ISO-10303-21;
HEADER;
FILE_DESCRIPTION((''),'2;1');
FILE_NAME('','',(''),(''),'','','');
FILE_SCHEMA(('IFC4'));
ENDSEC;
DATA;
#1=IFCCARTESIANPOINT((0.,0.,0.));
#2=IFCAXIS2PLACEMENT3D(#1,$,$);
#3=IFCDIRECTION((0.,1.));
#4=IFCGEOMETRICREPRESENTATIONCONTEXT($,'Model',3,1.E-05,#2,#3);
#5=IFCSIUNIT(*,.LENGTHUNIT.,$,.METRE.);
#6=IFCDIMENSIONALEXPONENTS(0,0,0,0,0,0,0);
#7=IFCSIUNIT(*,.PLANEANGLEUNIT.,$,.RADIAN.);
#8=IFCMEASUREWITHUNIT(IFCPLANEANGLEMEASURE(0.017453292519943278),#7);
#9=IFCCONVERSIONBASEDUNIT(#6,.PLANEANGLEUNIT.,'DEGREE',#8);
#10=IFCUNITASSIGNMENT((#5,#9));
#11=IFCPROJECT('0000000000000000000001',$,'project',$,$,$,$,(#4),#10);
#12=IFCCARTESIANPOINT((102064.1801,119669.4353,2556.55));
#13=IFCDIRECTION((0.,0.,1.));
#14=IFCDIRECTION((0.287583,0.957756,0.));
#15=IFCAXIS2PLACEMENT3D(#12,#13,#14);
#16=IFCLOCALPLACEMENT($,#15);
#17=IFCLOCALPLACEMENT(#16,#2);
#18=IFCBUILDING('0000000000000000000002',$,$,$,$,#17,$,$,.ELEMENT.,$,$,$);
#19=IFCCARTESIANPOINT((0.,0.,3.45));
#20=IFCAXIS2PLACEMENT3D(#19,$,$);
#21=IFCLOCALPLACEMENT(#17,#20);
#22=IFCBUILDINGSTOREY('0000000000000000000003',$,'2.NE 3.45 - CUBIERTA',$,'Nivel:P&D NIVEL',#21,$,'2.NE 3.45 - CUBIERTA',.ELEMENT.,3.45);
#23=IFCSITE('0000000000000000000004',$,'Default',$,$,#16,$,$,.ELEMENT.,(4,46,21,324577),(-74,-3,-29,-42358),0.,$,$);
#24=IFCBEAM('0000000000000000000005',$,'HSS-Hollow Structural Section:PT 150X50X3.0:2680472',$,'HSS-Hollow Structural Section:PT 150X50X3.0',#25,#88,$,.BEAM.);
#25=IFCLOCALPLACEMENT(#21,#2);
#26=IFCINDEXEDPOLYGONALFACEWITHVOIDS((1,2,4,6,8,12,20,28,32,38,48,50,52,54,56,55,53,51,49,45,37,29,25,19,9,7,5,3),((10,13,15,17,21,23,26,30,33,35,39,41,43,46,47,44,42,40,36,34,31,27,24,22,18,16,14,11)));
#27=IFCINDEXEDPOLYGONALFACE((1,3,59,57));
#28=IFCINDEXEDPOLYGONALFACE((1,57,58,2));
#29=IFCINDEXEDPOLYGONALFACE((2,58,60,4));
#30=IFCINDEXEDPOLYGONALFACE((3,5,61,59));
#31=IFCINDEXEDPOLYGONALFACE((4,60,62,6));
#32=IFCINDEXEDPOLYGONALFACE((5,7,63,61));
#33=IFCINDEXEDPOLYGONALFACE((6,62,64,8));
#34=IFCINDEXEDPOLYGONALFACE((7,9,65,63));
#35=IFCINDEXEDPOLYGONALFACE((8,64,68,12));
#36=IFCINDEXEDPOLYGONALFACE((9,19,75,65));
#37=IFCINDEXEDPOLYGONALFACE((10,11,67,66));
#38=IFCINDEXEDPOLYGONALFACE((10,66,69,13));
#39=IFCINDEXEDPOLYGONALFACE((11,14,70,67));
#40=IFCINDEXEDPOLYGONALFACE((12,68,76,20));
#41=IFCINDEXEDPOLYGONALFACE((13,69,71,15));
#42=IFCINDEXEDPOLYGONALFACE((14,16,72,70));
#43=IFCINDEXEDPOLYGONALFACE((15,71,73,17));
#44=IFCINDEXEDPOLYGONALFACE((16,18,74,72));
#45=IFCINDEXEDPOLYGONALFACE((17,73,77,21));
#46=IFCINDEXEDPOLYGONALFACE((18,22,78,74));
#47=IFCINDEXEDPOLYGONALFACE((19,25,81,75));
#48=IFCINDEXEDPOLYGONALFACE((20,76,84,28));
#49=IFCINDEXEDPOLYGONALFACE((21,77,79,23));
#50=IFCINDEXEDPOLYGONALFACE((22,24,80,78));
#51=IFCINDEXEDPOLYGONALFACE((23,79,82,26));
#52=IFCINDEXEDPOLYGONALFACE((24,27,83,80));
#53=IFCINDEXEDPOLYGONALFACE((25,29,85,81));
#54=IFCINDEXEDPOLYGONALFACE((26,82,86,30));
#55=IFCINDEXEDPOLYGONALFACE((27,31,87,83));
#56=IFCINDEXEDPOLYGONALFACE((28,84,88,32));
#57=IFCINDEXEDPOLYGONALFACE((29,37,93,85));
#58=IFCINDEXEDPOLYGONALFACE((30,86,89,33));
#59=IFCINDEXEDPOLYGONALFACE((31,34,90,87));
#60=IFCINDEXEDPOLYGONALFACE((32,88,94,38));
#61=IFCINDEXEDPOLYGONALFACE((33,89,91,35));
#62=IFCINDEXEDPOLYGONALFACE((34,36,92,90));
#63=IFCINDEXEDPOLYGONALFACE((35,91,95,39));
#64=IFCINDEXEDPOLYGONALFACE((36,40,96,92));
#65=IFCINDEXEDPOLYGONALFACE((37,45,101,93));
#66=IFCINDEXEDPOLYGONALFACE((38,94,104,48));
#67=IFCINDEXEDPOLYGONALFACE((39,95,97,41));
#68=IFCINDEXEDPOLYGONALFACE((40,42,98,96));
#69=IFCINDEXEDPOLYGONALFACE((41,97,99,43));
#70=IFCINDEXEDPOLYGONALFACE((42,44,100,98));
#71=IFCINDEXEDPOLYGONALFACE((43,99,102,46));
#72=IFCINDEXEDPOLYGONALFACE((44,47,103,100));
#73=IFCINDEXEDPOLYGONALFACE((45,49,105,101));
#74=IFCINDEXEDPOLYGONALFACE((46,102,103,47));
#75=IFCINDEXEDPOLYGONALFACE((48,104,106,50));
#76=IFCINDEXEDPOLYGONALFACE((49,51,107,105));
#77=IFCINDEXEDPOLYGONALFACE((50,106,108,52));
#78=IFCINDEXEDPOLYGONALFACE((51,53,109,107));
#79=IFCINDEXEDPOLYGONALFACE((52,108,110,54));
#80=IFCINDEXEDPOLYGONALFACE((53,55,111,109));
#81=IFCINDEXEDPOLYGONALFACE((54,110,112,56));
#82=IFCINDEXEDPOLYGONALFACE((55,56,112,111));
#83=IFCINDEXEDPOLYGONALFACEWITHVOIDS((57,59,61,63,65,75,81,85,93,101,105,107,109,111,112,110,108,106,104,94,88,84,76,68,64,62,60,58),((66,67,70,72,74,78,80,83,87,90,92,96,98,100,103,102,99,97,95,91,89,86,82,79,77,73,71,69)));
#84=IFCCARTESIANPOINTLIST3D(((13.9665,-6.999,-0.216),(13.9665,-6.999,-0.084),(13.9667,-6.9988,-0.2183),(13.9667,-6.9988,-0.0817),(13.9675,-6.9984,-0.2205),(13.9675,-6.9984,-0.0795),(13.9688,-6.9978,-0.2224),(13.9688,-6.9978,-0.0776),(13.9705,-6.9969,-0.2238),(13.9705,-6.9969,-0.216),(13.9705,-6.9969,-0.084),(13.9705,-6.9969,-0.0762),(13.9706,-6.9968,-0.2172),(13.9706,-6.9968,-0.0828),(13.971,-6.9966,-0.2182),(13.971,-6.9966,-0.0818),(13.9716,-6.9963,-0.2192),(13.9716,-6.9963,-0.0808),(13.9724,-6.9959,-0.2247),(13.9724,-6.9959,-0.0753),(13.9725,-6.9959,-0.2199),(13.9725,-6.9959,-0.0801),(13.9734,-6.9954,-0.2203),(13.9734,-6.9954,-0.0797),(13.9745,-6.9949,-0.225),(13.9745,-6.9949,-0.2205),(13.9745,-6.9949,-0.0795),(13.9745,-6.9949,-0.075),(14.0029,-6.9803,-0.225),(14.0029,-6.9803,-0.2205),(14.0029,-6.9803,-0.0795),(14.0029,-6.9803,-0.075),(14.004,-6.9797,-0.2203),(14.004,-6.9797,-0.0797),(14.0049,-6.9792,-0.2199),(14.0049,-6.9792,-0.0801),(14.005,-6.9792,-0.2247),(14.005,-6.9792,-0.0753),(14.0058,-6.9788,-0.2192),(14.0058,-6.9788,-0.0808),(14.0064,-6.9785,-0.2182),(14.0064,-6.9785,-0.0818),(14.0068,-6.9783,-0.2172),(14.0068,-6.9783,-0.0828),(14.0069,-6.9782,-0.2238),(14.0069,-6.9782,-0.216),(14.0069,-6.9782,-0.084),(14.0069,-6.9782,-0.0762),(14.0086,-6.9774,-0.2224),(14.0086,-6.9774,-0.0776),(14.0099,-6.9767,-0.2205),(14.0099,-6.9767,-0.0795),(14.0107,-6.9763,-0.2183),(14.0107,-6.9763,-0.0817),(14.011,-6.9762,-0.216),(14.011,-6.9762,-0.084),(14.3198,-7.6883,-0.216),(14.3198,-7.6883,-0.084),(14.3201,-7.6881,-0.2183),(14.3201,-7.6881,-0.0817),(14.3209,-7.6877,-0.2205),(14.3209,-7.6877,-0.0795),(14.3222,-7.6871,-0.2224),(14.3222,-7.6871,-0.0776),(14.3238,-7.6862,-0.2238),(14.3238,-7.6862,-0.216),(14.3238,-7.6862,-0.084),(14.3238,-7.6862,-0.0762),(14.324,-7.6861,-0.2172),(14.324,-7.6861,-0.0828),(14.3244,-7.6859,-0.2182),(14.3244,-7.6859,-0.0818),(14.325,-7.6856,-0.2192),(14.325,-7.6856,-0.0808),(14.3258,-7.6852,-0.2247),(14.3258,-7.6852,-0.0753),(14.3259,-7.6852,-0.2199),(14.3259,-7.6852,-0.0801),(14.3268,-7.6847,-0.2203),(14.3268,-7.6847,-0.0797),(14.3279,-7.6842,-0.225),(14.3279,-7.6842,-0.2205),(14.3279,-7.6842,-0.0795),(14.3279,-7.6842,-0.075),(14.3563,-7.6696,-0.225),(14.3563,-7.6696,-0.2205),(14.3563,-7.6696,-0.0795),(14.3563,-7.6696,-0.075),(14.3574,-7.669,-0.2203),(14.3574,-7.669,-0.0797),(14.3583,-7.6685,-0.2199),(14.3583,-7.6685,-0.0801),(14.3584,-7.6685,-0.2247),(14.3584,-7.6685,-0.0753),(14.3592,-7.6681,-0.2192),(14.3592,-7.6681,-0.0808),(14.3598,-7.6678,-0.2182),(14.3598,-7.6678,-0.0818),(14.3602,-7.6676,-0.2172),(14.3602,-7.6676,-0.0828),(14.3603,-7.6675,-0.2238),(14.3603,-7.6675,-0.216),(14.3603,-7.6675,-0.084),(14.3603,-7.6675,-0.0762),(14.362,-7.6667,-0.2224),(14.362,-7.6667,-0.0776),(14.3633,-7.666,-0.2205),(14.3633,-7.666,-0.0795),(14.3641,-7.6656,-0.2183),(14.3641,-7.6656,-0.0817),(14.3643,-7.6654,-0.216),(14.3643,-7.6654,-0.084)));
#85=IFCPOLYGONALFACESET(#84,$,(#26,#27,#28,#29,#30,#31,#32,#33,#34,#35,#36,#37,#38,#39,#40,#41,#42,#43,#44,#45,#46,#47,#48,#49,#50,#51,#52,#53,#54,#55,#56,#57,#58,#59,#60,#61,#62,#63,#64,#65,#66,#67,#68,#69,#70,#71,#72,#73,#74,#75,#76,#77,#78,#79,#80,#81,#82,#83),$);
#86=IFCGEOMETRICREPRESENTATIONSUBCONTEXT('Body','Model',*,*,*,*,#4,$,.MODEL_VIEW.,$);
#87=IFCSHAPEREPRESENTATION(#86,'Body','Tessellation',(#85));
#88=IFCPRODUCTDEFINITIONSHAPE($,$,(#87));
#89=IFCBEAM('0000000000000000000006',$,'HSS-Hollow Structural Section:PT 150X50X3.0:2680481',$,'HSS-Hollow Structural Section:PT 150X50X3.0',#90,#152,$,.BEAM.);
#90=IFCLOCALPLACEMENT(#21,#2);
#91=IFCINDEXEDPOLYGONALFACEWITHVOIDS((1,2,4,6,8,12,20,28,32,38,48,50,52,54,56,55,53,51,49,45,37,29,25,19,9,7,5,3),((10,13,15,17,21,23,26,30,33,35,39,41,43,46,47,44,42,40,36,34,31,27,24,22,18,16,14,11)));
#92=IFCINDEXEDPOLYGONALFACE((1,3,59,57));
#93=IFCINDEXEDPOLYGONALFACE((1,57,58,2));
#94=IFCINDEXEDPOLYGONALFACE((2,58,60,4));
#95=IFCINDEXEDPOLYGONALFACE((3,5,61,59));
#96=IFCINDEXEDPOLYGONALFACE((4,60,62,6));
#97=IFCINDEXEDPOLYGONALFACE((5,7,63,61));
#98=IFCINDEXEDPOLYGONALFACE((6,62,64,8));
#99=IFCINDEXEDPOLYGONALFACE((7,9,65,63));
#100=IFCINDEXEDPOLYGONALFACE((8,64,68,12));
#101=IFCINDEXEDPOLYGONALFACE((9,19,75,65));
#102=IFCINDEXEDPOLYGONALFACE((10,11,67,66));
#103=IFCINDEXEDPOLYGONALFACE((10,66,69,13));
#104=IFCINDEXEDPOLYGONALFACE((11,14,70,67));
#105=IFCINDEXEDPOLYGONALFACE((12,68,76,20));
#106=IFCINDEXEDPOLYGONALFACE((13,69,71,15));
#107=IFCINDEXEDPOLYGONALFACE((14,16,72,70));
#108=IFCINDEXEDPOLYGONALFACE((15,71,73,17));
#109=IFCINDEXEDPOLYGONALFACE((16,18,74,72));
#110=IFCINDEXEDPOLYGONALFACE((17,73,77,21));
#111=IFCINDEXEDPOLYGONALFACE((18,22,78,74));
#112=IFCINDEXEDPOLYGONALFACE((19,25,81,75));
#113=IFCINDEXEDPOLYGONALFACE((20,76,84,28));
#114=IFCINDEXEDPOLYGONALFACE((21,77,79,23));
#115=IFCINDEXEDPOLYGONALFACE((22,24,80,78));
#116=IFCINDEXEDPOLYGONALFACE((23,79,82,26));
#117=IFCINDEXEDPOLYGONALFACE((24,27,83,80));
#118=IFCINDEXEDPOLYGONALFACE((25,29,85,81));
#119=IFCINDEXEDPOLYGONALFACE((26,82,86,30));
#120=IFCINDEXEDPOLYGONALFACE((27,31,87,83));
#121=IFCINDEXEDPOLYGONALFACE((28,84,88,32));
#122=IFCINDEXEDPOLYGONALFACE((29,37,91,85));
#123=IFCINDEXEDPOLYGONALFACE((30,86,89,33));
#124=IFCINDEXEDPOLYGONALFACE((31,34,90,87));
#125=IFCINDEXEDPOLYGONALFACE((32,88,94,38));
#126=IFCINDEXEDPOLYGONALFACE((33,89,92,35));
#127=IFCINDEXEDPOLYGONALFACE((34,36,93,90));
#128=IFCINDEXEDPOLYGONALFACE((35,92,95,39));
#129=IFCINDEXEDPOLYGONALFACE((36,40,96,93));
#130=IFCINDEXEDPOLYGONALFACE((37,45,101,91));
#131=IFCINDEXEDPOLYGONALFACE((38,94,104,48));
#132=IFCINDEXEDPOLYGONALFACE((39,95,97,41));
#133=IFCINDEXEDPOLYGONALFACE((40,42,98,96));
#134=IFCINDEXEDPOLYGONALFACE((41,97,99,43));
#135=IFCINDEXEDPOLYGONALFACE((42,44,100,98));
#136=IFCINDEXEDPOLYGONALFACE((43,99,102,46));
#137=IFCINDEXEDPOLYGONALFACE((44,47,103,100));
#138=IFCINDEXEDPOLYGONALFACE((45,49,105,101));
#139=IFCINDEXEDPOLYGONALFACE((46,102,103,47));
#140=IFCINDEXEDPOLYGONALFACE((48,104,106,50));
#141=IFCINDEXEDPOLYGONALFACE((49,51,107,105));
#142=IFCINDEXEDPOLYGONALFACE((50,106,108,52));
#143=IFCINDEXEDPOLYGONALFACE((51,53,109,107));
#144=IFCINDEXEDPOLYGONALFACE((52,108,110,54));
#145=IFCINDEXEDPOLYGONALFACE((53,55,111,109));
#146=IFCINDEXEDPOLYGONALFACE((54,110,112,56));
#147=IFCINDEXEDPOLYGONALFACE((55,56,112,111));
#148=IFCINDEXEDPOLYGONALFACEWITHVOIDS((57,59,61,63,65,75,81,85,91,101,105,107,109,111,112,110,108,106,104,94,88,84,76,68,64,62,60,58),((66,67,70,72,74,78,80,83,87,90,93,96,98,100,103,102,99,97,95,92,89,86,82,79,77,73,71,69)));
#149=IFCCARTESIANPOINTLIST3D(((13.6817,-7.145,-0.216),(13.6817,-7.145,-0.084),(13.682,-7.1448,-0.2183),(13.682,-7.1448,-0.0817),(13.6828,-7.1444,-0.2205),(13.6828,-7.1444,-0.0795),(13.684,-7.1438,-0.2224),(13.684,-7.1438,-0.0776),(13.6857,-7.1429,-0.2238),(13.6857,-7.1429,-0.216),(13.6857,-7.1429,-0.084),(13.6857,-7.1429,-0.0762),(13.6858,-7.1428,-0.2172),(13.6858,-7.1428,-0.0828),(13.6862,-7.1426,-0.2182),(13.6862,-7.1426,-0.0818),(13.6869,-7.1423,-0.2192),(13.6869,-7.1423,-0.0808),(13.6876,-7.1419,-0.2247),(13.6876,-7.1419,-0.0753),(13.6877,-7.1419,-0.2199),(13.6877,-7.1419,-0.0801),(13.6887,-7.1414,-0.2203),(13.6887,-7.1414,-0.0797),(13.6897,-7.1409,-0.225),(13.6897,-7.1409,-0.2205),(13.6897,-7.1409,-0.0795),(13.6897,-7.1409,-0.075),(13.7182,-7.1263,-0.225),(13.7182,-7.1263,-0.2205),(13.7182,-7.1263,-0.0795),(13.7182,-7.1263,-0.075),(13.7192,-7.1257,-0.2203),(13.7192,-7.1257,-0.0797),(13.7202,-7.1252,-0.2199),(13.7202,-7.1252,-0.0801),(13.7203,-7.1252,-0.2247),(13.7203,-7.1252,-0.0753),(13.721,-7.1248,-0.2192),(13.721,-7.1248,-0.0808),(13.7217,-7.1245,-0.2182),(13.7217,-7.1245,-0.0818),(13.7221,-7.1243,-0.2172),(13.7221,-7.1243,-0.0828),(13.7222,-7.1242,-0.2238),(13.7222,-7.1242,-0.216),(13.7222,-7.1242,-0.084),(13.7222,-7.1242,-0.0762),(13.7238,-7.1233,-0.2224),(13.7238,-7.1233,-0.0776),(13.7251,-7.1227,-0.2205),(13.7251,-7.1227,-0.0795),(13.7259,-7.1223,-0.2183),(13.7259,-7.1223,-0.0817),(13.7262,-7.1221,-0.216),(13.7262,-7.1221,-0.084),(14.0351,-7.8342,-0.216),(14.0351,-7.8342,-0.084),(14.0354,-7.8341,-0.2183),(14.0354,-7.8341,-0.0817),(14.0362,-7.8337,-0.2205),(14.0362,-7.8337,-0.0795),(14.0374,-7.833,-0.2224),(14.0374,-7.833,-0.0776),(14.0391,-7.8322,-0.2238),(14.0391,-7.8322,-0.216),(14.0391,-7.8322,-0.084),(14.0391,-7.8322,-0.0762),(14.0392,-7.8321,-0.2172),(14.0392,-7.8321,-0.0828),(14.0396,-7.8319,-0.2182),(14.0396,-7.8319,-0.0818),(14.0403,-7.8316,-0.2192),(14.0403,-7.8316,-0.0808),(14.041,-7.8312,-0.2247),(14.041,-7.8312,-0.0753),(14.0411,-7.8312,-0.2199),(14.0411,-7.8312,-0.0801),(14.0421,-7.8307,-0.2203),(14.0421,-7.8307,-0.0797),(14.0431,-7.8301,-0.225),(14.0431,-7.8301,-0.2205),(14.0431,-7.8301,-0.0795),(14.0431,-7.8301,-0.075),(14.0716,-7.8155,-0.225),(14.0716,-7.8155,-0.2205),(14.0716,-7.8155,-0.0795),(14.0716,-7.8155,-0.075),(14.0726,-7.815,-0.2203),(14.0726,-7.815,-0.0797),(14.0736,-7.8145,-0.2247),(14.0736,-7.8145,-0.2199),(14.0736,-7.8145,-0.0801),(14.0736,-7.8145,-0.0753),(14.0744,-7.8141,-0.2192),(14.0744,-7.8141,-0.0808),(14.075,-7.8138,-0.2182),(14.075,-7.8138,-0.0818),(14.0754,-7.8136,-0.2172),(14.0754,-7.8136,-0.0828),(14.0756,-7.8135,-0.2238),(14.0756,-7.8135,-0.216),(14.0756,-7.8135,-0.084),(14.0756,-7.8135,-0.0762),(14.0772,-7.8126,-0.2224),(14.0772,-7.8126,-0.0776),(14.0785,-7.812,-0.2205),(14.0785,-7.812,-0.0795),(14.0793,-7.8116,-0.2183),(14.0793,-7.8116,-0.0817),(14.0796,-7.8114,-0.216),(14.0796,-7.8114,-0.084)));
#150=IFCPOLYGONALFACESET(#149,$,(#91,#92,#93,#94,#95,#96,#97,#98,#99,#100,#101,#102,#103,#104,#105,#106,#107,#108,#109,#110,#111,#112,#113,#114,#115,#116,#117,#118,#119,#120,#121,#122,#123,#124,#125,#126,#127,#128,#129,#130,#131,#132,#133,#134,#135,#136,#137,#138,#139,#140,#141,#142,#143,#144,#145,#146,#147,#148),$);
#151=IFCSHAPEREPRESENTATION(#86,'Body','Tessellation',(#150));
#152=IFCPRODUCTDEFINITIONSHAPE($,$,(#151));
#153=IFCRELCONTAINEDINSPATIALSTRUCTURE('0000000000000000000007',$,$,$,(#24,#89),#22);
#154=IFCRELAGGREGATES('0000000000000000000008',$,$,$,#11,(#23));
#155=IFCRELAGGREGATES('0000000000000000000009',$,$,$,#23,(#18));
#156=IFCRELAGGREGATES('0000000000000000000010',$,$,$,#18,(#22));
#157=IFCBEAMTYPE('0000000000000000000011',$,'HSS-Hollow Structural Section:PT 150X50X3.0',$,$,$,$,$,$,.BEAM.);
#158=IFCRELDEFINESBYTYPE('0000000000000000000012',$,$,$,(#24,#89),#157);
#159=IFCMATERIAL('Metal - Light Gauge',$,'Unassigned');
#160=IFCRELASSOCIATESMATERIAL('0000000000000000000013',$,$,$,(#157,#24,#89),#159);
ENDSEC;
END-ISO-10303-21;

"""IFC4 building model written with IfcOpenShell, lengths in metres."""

from ifc_helpers import new_model, entity, si_unit, converted_unit, direction, frame, origin, place, context, subcontext, project, spatial, line, arc, indexed_curve, outline, extrude, source, transform, mapped, material, type_object, type_shapes, element, save


model = new_model("IFC4")

# Units and contexts
model_context = context("Model", 3, precision=1e-05, world=origin(), true_north=direction((0.0, 1.0)))
body_context = subcontext(model_context, "Body", "Model", "MODEL_VIEW")
ifc_project = project(units=[si_unit("LENGTHUNIT", "METRE"), converted_unit("PLANEANGLEUNIT", "DEGREE", entity("IfcPlaneAngleMeasure", 0.017453292519943278), si_unit("PLANEANGLEUNIT", "RADIAN"), dimensions=[0, 0, 0, 0, 0, 0, 0])], contexts=[model_context])

# Site, building, storey
site_placement = place(None, frame((102064.1801, 119669.4353, 2556.55), z_axis=(0.0, 0.0, 1.0), x_axis=(0.287583, 0.957756, 0.0)))
site = spatial("IfcSite", under=ifc_project, at=site_placement, Name="Default", CompositionType="ELEMENT", RefLatitude=(4, 46, 21, 324577), RefLongitude=(-74, -3, -29, -42358), RefElevation=0.0)
building_placement = place(site_placement, origin())
building = spatial("IfcBuilding", under=site, at=building_placement, CompositionType="ELEMENT")
storey_placement = place(building_placement, frame((0.0, 0.0, 3.45)))
storey = spatial("IfcBuildingStorey", under=building, at=storey_placement, Name="2.NE 3.45 - CUBIERTA", ObjectType="Nivel:P&D NIVEL", LongName="2.NE 3.45 - CUBIERTA", CompositionType="ELEMENT", Elevation=3.45)

# Beams
ifc_material_1 = material(Name="Metal - Light Gauge", Category="Unassigned")
beam_type_1 = type_object("IfcBeamType", Name="HSS-Hollow Structural Section:PT 150X50X3.0", PredefinedType="BEAM", material=ifc_material_1)
shared_shape_1 = source(origin(), body_context, "Body", "SweptSolid", [
    extrude(outline(indexed_curve([(-0.025, -0.066), (-0.0224, -0.0724), (-0.016, -0.075), (0.016, -0.075), (0.0224, -0.0724), (0.025, -0.066), (0.025, 0.066), (0.0224, 0.0724), (0.016, 0.075), (-0.016, 0.075), (-0.0224, 0.0724), (-0.025, 0.066)], segments=[arc(1, 2, 3), line(3, 4), arc(4, 5, 6), line(6, 7), arc(7, 8, 9), line(9, 10), arc(10, 11, 12), line(12, 1)], self_intersect=False), holes=[indexed_curve([(0.016, -0.0705), (-0.016, -0.0705), (-0.0192, -0.0692), (-0.0205, -0.066), (-0.0205, 0.066), (-0.0192, 0.0692), (-0.016, 0.0705), (0.016, 0.0705), (0.0192, 0.0692), (0.0205, 0.066), (0.0205, -0.066), (0.0192, -0.0692)], segments=[line(1, 2), arc(2, 3, 4), line(4, 5), arc(5, 6, 7), line(7, 8), arc(8, 9, 10), line(10, 11), arc(11, 12, 1)], self_intersect=False)]), frame((-0.3873, 0.0, 0.0), z_axis=(1.0, 0.0, 0.0), x_axis=(0.0, -1.0, 0.0)), (0.0, 0.0, 1.0), 0.7746),
])
type_shapes(beam_type_1, [shared_shape_1])
for number, where, z_axis, x_axis, name in (
    (1, (14.1654, -7.3322, -0.15), (0.0, 0.0, 1.0), (-0.456217, 0.889869, 0.0), "HSS-Hollow Structural Section:PT 150X50X3.0:2680472"),
    (2, (13.8806, -7.4782, -0.15), (0.0, 0.0, 1.0), (-0.456217, 0.889869, 0.0), "HSS-Hollow Structural Section:PT 150X50X3.0:2680481"),
):
    element("IfcBeam", number, at=place(storey_placement, frame(where, z_axis=z_axis, x_axis=x_axis)), inside=storey, type_object=beam_type_1, material=ifc_material_1, Name=name, ObjectType="HSS-Hollow Structural Section:PT 150X50X3.0", PredefinedType="BEAM", context=body_context, shape_type="MappedRepresentation", body=[
        mapped(shared_shape_1, transform((0.0, 0.0, 0.0), scale=1.0)),
    ])

save(model, "model.ifc")
